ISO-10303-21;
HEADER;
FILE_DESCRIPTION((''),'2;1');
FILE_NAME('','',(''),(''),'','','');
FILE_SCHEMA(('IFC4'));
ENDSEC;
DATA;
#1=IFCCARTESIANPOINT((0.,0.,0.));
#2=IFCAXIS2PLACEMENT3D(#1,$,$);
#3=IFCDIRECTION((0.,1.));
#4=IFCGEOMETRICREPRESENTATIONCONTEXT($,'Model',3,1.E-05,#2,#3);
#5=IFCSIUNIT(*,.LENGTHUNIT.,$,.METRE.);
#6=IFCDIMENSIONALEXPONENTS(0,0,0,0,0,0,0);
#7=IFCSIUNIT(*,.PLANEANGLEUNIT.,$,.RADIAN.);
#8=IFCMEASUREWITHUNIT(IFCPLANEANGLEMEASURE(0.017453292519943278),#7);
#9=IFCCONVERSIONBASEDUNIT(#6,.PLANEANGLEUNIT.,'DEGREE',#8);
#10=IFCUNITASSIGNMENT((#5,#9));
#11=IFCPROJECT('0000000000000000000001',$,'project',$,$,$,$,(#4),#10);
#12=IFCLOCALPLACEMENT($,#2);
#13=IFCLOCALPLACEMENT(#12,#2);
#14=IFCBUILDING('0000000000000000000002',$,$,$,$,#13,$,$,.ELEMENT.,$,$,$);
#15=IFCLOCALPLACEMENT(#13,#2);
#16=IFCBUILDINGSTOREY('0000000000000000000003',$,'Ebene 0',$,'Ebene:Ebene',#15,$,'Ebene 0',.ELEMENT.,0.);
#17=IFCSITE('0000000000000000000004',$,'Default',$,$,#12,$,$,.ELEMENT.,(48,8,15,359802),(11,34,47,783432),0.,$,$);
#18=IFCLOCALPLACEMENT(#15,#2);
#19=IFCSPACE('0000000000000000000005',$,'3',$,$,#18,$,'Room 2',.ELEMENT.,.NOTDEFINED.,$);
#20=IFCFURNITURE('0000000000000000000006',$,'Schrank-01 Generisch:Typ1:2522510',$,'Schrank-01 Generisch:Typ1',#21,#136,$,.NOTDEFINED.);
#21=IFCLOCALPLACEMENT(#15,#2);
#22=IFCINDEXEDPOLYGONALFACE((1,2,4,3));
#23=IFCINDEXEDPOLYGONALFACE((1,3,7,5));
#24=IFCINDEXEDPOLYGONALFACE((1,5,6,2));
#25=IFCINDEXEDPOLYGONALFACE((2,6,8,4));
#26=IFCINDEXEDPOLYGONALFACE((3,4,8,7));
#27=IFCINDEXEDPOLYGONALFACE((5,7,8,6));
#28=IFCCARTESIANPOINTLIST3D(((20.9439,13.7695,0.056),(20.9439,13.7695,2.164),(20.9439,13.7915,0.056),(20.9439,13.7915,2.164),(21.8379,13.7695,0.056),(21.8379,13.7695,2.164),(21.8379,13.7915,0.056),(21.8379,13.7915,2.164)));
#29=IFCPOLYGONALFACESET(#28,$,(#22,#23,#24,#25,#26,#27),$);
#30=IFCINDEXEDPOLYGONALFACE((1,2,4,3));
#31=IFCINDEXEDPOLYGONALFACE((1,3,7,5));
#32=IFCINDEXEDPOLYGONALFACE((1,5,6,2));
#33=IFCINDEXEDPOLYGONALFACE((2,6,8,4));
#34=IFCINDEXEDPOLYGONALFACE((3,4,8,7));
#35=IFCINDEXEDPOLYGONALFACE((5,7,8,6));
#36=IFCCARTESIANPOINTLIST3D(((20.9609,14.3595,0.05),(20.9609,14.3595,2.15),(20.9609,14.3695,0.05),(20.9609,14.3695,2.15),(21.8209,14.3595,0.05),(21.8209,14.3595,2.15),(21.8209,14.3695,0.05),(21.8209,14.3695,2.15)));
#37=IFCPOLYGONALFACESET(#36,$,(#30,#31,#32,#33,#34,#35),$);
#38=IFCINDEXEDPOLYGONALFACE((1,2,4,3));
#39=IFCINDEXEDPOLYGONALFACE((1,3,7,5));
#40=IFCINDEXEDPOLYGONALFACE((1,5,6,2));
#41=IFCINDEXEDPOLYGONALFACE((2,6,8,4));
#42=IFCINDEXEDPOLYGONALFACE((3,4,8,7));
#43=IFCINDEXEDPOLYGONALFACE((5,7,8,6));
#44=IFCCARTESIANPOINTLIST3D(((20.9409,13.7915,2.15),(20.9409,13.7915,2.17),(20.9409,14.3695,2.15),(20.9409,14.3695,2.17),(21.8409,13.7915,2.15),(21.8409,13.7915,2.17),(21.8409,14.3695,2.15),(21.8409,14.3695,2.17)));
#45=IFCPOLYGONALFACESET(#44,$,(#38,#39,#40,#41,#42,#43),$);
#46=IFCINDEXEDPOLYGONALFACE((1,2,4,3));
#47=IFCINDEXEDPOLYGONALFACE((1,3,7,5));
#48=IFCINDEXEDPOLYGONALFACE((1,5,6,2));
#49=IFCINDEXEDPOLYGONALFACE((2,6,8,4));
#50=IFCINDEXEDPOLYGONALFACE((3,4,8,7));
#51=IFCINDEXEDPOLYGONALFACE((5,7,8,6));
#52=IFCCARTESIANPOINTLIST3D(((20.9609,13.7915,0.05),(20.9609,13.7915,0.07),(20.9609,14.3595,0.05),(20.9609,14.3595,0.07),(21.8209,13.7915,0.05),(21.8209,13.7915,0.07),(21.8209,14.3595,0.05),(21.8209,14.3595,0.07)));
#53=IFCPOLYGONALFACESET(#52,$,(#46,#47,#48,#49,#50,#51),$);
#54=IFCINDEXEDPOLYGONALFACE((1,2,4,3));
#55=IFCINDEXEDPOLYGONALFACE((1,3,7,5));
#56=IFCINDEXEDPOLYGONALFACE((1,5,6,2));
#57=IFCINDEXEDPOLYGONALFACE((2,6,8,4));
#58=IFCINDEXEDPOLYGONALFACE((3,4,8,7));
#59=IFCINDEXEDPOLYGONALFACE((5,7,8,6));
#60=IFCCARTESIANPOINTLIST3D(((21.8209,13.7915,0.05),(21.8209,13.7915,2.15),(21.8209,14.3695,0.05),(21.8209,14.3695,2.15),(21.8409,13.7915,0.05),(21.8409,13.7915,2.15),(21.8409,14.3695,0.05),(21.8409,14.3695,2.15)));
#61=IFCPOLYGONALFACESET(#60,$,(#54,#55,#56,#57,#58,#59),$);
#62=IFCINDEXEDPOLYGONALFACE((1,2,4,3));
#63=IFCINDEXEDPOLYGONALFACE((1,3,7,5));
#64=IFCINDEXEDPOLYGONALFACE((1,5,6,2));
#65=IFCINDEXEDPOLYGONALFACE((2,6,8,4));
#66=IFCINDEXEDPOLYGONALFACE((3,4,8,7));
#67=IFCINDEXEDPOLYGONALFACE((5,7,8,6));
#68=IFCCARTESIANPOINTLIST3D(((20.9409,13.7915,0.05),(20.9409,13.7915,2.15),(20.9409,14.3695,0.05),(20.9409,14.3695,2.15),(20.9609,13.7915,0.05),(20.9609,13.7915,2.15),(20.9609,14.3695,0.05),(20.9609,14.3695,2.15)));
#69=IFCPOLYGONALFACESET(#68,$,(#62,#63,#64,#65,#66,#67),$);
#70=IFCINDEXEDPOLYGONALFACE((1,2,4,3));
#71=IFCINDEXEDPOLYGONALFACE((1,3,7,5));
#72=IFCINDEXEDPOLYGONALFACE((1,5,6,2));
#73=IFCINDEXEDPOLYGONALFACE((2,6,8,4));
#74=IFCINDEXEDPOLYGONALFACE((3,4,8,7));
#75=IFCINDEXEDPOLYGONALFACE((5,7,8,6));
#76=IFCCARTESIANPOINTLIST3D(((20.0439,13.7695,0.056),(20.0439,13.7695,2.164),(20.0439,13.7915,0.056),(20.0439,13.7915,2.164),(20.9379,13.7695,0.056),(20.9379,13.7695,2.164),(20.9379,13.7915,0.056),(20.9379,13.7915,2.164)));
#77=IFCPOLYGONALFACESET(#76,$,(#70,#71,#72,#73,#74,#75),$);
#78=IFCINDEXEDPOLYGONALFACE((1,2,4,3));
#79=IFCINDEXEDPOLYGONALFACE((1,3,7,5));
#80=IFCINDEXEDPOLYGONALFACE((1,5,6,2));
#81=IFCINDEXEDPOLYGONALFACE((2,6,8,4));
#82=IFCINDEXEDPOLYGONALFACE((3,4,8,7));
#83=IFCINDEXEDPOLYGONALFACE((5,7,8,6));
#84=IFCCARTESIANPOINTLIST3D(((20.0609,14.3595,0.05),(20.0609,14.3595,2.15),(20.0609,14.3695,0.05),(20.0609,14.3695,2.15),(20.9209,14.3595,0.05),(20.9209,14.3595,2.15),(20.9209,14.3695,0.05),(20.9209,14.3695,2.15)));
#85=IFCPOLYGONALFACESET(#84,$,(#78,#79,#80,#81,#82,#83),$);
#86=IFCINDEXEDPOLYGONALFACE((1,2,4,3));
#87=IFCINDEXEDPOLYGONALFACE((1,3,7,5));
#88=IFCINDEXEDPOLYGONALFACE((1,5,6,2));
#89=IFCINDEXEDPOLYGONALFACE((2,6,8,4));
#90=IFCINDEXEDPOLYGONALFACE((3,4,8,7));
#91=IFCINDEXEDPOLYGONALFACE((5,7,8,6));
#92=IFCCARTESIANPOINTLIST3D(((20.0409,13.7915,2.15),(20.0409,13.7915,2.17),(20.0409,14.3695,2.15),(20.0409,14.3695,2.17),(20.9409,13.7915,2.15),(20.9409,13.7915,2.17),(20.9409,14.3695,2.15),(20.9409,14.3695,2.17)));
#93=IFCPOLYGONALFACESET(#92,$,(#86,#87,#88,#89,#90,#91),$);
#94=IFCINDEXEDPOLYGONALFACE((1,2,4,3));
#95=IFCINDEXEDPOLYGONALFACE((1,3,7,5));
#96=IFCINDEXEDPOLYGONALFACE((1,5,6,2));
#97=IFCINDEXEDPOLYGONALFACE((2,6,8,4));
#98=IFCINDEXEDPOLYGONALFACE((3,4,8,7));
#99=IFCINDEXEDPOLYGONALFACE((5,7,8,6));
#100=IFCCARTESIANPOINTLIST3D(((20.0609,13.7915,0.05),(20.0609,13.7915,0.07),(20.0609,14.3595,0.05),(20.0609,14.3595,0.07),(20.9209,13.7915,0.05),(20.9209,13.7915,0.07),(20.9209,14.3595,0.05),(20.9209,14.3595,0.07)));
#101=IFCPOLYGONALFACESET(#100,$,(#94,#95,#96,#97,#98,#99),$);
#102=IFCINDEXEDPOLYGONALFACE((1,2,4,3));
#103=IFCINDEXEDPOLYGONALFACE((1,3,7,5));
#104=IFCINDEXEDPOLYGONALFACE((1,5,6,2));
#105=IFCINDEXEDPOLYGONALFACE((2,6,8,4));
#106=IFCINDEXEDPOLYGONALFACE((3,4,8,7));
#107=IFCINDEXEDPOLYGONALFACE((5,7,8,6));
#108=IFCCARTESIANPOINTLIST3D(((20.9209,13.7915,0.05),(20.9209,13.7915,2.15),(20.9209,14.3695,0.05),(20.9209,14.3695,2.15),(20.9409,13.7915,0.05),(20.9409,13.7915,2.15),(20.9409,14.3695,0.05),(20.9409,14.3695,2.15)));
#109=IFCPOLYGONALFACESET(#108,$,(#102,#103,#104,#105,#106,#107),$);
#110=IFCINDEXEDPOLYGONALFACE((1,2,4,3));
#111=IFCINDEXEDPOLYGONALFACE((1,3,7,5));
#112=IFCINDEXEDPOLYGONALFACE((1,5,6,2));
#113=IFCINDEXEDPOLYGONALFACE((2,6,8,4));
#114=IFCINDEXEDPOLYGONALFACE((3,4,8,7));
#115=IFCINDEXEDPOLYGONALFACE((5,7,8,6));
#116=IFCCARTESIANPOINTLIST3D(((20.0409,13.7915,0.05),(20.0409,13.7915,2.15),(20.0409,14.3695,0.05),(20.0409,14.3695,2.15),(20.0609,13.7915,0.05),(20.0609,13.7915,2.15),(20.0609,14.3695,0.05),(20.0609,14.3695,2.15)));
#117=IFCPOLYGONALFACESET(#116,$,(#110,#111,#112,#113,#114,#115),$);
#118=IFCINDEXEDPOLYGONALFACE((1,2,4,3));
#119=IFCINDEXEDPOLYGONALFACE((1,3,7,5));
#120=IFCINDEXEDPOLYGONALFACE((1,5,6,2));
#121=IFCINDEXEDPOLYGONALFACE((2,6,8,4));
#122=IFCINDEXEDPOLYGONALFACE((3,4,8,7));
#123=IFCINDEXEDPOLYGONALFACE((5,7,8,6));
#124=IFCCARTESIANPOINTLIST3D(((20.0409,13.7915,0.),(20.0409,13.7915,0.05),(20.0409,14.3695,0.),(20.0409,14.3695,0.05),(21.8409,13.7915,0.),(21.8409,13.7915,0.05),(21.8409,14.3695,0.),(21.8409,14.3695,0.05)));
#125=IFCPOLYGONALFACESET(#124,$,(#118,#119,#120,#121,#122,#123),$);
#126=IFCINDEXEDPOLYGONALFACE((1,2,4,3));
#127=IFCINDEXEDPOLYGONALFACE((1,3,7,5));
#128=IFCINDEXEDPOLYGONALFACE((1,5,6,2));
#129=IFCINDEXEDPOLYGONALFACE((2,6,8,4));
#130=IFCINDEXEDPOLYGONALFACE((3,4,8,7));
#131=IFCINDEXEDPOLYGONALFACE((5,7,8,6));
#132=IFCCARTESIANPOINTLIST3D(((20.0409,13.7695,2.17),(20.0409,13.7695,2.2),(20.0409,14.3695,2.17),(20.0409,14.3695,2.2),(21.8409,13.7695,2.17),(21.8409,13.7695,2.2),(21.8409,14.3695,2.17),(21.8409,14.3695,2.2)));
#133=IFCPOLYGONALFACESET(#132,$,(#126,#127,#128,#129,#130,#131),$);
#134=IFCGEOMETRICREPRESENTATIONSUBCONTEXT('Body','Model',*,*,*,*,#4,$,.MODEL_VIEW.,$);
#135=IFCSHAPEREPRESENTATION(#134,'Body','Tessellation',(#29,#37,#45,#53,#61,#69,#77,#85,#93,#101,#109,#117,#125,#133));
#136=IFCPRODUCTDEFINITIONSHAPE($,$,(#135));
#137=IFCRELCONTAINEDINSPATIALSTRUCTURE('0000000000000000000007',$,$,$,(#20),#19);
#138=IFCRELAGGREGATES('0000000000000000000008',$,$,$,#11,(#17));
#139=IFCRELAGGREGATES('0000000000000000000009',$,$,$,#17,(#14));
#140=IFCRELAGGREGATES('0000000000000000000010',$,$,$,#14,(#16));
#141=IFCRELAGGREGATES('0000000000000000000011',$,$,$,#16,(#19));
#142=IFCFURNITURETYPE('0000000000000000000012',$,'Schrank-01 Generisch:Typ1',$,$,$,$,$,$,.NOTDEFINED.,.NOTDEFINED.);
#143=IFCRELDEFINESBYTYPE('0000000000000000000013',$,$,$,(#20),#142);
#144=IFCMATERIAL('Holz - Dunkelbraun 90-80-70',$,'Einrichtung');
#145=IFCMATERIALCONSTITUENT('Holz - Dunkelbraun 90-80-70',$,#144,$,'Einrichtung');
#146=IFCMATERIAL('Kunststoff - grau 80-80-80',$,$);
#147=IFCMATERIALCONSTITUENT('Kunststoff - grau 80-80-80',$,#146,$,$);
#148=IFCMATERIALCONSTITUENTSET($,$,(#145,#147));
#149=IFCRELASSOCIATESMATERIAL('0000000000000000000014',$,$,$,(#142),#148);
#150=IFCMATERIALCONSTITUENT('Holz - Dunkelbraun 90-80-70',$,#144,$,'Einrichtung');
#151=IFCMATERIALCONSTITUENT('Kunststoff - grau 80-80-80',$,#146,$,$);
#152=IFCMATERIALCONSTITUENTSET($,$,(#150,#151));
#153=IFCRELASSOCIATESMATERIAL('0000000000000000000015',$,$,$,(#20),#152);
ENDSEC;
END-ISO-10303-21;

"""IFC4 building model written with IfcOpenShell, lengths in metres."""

from ifc_helpers import new_model, entity, si_unit, converted_unit, direction, frame, origin, place, context, subcontext, project, spatial, indexed_curve, outline, extrude, source, transform, mapped, material, constituent, constituent_set, type_object, type_shapes, element, save


model = new_model("IFC4")

# Units and contexts
model_context = context("Model", 3, precision=1e-05, world=origin(), true_north=direction((0.0, 1.0)))
body_context = subcontext(model_context, "Body", "Model", "MODEL_VIEW")
ifc_project = project(units=[si_unit("LENGTHUNIT", "METRE"), converted_unit("PLANEANGLEUNIT", "DEGREE", entity("IfcPlaneAngleMeasure", 0.017453292519943278), si_unit("PLANEANGLEUNIT", "RADIAN"), dimensions=[0, 0, 0, 0, 0, 0, 0])], contexts=[model_context])

# Site, building, storey
site_placement = place(None, origin())
site = spatial("IfcSite", under=ifc_project, at=site_placement, Name="Default", CompositionType="ELEMENT", RefLatitude=(48, 8, 15, 359802), RefLongitude=(11, 34, 47, 783432), RefElevation=0.0)
building_placement = place(site_placement, origin())
building = spatial("IfcBuilding", under=site, at=building_placement, CompositionType="ELEMENT")
storey_placement = place(building_placement, origin())
storey = spatial("IfcBuildingStorey", under=building, at=storey_placement, Name="Ebene 0", ObjectType="Ebene:Ebene", LongName="Ebene 0", CompositionType="ELEMENT", Elevation=0.0)

# Shared definitions
ifc_material_1 = material(Name="Holz - Dunkelbraun 90-80-70", Category="Einrichtung")
ifc_material_2 = material(Name="Kunststoff - grau 80-80-80")

# Shared definitions
ifc_constituent_1 = constituent(ifc_material_1, Name="Holz - Dunkelbraun 90-80-70", Category="Einrichtung")
ifc_constituent_2 = constituent(ifc_material_2, Name="Kunststoff - grau 80-80-80")
ifc_constituent_set_1 = constituent_set(constituents=[ifc_constituent_1, ifc_constituent_2])
furniture_type_1 = type_object("IfcFurnitureType", Name="Schrank-01 Generisch:Typ1", AssemblyPlace="NOTDEFINED", PredefinedType="NOTDEFINED", material=ifc_constituent_set_1)
shared_shape_1 = source(origin(), body_context, "Body", "SweptSolid", [
    extrude(outline(indexed_curve([(-0.447, -0.011), (0.447, -0.011), (0.447, 0.011), (-0.447, 0.011), (-0.447, -0.011)], self_intersect=False)), frame((0.45, -0.289, 0.056), z_axis=(0.0, 0.0, 1.0), x_axis=(-1.0, 0.0, 0.0)), (0.0, 0.0, 1.0), 2.108),
    extrude(outline(indexed_curve([(-0.43, -0.005), (0.43, -0.005), (0.43, 0.005), (-0.43, 0.005), (-0.43, -0.005)], self_intersect=False)), frame((0.45, 0.295, 0.05), z_axis=(0.0, 0.0, 1.0), x_axis=(-1.0, 0.0, 0.0)), (0.0, 0.0, 1.0), 2.1),
    extrude(outline(indexed_curve([(-0.45, -0.289), (0.45, -0.289), (0.45, 0.289), (-0.45, 0.289), (-0.45, -0.289)], self_intersect=False)), frame((0.45, 0.011, 2.15), z_axis=(0.0, 0.0, 1.0), x_axis=(-1.0, 0.0, 0.0)), (0.0, 0.0, 1.0), 0.02),
    extrude(outline(indexed_curve([(-0.43, -0.284), (0.43, -0.284), (0.43, 0.284), (-0.43, 0.284), (-0.43, -0.284)], self_intersect=False)), frame((0.45, 0.006, 0.05), z_axis=(0.0, 0.0, 1.0), x_axis=(-1.0, 0.0, 0.0)), (0.0, 0.0, 1.0), 0.02),
    extrude(outline(indexed_curve([(-0.01, -0.289), (0.01, -0.289), (0.01, 0.289), (-0.01, 0.289), (-0.01, -0.289)], self_intersect=False)), frame((0.89, 0.011, 0.05), z_axis=(0.0, 0.0, 1.0), x_axis=(-1.0, 0.0, 0.0)), (0.0, 0.0, 1.0), 2.1),
    extrude(outline(indexed_curve([(-0.01, -0.289), (0.01, -0.289), (0.01, 0.289), (-0.01, 0.289), (-0.01, -0.289)], self_intersect=False)), frame((0.01, 0.011, 0.05), z_axis=(0.0, 0.0, 1.0), x_axis=(-1.0, 0.0, 0.0)), (0.0, 0.0, 1.0), 2.1),
    extrude(outline(indexed_curve([(-0.447, -0.011), (0.447, -0.011), (0.447, 0.011), (-0.447, 0.011), (-0.447, -0.011)], self_intersect=False)), frame((-0.45, -0.289, 0.056), z_axis=(0.0, 0.0, 1.0), x_axis=(-1.0, 0.0, 0.0)), (0.0, 0.0, 1.0), 2.108),
    extrude(outline(indexed_curve([(-0.43, -0.005), (0.43, -0.005), (0.43, 0.005), (-0.43, 0.005), (-0.43, -0.005)], self_intersect=False)), frame((-0.45, 0.295, 0.05), z_axis=(0.0, 0.0, 1.0), x_axis=(-1.0, 0.0, 0.0)), (0.0, 0.0, 1.0), 2.1),
    extrude(outline(indexed_curve([(-0.45, -0.289), (0.45, -0.289), (0.45, 0.289), (-0.45, 0.289), (-0.45, -0.289)], self_intersect=False)), frame((-0.45, 0.011, 2.15), z_axis=(0.0, 0.0, 1.0), x_axis=(-1.0, 0.0, 0.0)), (0.0, 0.0, 1.0), 0.02),
    extrude(outline(indexed_curve([(-0.43, -0.284), (0.43, -0.284), (0.43, 0.284), (-0.43, 0.284), (-0.43, -0.284)], self_intersect=False)), frame((-0.45, 0.006, 0.05), z_axis=(0.0, 0.0, 1.0), x_axis=(-1.0, 0.0, 0.0)), (0.0, 0.0, 1.0), 0.02),
    extrude(outline(indexed_curve([(-0.01, -0.289), (0.01, -0.289), (0.01, 0.289), (-0.01, 0.289), (-0.01, -0.289)], self_intersect=False)), frame((-0.01, 0.011, 0.05), z_axis=(0.0, 0.0, 1.0), x_axis=(-1.0, 0.0, 0.0)), (0.0, 0.0, 1.0), 2.1),
    extrude(outline(indexed_curve([(-0.01, -0.289), (0.01, -0.289), (0.01, 0.289), (-0.01, 0.289), (-0.01, -0.289)], self_intersect=False)), frame((-0.89, 0.011, 0.05), z_axis=(0.0, 0.0, 1.0), x_axis=(-1.0, 0.0, 0.0)), (0.0, 0.0, 1.0), 2.1),
    extrude(outline(indexed_curve([(-0.9, -0.289), (0.9, -0.289), (0.9, 0.289), (-0.9, 0.289), (-0.9, -0.289)], self_intersect=False)), frame((0.0, 0.011, 0.0), z_axis=(0.0, 0.0, 1.0), x_axis=(-1.0, 0.0, 0.0)), (0.0, 0.0, 1.0), 0.05),
    extrude(outline(indexed_curve([(-0.9, -0.3), (0.9, -0.3), (0.9, 0.3), (-0.9, 0.3), (-0.9, -0.3)], self_intersect=False)), frame((0.0, 0.0, 2.17), z_axis=(0.0, 0.0, 1.0), x_axis=(-1.0, 0.0, 0.0)), (0.0, 0.0, 1.0), 0.03),
])
type_shapes(furniture_type_1, [shared_shape_1])

# Shared definitions
space_1_placement = place(storey_placement, origin())
space_1 = spatial("IfcSpace", under=storey, at=space_1_placement, Name="3", LongName="Room 2", CompositionType="ELEMENT", PredefinedType="NOTDEFINED")

# Furniture
ifc_constituent_3 = constituent(ifc_material_1, Name="Holz - Dunkelbraun 90-80-70", Category="Einrichtung")
ifc_constituent_4 = constituent(ifc_material_2, Name="Kunststoff - grau 80-80-80")
ifc_constituent_set_2 = constituent_set(constituents=[ifc_constituent_3, ifc_constituent_4])
furniture_1_placement = place(space_1_placement, frame((20.9409, 14.0695, 0.0)))
element("IfcFurniture", 1, at=furniture_1_placement, inside=space_1, type_object=furniture_type_1, material=ifc_constituent_set_2, Name="Schrank-01 Generisch:Typ1:2522510", ObjectType="Schrank-01 Generisch:Typ1", PredefinedType="NOTDEFINED", context=body_context, shape_type="MappedRepresentation", body=[
    mapped(shared_shape_1, transform((0.0, 0.0, 0.0), scale=1.0)),
])

save(model, "model.ifc")
